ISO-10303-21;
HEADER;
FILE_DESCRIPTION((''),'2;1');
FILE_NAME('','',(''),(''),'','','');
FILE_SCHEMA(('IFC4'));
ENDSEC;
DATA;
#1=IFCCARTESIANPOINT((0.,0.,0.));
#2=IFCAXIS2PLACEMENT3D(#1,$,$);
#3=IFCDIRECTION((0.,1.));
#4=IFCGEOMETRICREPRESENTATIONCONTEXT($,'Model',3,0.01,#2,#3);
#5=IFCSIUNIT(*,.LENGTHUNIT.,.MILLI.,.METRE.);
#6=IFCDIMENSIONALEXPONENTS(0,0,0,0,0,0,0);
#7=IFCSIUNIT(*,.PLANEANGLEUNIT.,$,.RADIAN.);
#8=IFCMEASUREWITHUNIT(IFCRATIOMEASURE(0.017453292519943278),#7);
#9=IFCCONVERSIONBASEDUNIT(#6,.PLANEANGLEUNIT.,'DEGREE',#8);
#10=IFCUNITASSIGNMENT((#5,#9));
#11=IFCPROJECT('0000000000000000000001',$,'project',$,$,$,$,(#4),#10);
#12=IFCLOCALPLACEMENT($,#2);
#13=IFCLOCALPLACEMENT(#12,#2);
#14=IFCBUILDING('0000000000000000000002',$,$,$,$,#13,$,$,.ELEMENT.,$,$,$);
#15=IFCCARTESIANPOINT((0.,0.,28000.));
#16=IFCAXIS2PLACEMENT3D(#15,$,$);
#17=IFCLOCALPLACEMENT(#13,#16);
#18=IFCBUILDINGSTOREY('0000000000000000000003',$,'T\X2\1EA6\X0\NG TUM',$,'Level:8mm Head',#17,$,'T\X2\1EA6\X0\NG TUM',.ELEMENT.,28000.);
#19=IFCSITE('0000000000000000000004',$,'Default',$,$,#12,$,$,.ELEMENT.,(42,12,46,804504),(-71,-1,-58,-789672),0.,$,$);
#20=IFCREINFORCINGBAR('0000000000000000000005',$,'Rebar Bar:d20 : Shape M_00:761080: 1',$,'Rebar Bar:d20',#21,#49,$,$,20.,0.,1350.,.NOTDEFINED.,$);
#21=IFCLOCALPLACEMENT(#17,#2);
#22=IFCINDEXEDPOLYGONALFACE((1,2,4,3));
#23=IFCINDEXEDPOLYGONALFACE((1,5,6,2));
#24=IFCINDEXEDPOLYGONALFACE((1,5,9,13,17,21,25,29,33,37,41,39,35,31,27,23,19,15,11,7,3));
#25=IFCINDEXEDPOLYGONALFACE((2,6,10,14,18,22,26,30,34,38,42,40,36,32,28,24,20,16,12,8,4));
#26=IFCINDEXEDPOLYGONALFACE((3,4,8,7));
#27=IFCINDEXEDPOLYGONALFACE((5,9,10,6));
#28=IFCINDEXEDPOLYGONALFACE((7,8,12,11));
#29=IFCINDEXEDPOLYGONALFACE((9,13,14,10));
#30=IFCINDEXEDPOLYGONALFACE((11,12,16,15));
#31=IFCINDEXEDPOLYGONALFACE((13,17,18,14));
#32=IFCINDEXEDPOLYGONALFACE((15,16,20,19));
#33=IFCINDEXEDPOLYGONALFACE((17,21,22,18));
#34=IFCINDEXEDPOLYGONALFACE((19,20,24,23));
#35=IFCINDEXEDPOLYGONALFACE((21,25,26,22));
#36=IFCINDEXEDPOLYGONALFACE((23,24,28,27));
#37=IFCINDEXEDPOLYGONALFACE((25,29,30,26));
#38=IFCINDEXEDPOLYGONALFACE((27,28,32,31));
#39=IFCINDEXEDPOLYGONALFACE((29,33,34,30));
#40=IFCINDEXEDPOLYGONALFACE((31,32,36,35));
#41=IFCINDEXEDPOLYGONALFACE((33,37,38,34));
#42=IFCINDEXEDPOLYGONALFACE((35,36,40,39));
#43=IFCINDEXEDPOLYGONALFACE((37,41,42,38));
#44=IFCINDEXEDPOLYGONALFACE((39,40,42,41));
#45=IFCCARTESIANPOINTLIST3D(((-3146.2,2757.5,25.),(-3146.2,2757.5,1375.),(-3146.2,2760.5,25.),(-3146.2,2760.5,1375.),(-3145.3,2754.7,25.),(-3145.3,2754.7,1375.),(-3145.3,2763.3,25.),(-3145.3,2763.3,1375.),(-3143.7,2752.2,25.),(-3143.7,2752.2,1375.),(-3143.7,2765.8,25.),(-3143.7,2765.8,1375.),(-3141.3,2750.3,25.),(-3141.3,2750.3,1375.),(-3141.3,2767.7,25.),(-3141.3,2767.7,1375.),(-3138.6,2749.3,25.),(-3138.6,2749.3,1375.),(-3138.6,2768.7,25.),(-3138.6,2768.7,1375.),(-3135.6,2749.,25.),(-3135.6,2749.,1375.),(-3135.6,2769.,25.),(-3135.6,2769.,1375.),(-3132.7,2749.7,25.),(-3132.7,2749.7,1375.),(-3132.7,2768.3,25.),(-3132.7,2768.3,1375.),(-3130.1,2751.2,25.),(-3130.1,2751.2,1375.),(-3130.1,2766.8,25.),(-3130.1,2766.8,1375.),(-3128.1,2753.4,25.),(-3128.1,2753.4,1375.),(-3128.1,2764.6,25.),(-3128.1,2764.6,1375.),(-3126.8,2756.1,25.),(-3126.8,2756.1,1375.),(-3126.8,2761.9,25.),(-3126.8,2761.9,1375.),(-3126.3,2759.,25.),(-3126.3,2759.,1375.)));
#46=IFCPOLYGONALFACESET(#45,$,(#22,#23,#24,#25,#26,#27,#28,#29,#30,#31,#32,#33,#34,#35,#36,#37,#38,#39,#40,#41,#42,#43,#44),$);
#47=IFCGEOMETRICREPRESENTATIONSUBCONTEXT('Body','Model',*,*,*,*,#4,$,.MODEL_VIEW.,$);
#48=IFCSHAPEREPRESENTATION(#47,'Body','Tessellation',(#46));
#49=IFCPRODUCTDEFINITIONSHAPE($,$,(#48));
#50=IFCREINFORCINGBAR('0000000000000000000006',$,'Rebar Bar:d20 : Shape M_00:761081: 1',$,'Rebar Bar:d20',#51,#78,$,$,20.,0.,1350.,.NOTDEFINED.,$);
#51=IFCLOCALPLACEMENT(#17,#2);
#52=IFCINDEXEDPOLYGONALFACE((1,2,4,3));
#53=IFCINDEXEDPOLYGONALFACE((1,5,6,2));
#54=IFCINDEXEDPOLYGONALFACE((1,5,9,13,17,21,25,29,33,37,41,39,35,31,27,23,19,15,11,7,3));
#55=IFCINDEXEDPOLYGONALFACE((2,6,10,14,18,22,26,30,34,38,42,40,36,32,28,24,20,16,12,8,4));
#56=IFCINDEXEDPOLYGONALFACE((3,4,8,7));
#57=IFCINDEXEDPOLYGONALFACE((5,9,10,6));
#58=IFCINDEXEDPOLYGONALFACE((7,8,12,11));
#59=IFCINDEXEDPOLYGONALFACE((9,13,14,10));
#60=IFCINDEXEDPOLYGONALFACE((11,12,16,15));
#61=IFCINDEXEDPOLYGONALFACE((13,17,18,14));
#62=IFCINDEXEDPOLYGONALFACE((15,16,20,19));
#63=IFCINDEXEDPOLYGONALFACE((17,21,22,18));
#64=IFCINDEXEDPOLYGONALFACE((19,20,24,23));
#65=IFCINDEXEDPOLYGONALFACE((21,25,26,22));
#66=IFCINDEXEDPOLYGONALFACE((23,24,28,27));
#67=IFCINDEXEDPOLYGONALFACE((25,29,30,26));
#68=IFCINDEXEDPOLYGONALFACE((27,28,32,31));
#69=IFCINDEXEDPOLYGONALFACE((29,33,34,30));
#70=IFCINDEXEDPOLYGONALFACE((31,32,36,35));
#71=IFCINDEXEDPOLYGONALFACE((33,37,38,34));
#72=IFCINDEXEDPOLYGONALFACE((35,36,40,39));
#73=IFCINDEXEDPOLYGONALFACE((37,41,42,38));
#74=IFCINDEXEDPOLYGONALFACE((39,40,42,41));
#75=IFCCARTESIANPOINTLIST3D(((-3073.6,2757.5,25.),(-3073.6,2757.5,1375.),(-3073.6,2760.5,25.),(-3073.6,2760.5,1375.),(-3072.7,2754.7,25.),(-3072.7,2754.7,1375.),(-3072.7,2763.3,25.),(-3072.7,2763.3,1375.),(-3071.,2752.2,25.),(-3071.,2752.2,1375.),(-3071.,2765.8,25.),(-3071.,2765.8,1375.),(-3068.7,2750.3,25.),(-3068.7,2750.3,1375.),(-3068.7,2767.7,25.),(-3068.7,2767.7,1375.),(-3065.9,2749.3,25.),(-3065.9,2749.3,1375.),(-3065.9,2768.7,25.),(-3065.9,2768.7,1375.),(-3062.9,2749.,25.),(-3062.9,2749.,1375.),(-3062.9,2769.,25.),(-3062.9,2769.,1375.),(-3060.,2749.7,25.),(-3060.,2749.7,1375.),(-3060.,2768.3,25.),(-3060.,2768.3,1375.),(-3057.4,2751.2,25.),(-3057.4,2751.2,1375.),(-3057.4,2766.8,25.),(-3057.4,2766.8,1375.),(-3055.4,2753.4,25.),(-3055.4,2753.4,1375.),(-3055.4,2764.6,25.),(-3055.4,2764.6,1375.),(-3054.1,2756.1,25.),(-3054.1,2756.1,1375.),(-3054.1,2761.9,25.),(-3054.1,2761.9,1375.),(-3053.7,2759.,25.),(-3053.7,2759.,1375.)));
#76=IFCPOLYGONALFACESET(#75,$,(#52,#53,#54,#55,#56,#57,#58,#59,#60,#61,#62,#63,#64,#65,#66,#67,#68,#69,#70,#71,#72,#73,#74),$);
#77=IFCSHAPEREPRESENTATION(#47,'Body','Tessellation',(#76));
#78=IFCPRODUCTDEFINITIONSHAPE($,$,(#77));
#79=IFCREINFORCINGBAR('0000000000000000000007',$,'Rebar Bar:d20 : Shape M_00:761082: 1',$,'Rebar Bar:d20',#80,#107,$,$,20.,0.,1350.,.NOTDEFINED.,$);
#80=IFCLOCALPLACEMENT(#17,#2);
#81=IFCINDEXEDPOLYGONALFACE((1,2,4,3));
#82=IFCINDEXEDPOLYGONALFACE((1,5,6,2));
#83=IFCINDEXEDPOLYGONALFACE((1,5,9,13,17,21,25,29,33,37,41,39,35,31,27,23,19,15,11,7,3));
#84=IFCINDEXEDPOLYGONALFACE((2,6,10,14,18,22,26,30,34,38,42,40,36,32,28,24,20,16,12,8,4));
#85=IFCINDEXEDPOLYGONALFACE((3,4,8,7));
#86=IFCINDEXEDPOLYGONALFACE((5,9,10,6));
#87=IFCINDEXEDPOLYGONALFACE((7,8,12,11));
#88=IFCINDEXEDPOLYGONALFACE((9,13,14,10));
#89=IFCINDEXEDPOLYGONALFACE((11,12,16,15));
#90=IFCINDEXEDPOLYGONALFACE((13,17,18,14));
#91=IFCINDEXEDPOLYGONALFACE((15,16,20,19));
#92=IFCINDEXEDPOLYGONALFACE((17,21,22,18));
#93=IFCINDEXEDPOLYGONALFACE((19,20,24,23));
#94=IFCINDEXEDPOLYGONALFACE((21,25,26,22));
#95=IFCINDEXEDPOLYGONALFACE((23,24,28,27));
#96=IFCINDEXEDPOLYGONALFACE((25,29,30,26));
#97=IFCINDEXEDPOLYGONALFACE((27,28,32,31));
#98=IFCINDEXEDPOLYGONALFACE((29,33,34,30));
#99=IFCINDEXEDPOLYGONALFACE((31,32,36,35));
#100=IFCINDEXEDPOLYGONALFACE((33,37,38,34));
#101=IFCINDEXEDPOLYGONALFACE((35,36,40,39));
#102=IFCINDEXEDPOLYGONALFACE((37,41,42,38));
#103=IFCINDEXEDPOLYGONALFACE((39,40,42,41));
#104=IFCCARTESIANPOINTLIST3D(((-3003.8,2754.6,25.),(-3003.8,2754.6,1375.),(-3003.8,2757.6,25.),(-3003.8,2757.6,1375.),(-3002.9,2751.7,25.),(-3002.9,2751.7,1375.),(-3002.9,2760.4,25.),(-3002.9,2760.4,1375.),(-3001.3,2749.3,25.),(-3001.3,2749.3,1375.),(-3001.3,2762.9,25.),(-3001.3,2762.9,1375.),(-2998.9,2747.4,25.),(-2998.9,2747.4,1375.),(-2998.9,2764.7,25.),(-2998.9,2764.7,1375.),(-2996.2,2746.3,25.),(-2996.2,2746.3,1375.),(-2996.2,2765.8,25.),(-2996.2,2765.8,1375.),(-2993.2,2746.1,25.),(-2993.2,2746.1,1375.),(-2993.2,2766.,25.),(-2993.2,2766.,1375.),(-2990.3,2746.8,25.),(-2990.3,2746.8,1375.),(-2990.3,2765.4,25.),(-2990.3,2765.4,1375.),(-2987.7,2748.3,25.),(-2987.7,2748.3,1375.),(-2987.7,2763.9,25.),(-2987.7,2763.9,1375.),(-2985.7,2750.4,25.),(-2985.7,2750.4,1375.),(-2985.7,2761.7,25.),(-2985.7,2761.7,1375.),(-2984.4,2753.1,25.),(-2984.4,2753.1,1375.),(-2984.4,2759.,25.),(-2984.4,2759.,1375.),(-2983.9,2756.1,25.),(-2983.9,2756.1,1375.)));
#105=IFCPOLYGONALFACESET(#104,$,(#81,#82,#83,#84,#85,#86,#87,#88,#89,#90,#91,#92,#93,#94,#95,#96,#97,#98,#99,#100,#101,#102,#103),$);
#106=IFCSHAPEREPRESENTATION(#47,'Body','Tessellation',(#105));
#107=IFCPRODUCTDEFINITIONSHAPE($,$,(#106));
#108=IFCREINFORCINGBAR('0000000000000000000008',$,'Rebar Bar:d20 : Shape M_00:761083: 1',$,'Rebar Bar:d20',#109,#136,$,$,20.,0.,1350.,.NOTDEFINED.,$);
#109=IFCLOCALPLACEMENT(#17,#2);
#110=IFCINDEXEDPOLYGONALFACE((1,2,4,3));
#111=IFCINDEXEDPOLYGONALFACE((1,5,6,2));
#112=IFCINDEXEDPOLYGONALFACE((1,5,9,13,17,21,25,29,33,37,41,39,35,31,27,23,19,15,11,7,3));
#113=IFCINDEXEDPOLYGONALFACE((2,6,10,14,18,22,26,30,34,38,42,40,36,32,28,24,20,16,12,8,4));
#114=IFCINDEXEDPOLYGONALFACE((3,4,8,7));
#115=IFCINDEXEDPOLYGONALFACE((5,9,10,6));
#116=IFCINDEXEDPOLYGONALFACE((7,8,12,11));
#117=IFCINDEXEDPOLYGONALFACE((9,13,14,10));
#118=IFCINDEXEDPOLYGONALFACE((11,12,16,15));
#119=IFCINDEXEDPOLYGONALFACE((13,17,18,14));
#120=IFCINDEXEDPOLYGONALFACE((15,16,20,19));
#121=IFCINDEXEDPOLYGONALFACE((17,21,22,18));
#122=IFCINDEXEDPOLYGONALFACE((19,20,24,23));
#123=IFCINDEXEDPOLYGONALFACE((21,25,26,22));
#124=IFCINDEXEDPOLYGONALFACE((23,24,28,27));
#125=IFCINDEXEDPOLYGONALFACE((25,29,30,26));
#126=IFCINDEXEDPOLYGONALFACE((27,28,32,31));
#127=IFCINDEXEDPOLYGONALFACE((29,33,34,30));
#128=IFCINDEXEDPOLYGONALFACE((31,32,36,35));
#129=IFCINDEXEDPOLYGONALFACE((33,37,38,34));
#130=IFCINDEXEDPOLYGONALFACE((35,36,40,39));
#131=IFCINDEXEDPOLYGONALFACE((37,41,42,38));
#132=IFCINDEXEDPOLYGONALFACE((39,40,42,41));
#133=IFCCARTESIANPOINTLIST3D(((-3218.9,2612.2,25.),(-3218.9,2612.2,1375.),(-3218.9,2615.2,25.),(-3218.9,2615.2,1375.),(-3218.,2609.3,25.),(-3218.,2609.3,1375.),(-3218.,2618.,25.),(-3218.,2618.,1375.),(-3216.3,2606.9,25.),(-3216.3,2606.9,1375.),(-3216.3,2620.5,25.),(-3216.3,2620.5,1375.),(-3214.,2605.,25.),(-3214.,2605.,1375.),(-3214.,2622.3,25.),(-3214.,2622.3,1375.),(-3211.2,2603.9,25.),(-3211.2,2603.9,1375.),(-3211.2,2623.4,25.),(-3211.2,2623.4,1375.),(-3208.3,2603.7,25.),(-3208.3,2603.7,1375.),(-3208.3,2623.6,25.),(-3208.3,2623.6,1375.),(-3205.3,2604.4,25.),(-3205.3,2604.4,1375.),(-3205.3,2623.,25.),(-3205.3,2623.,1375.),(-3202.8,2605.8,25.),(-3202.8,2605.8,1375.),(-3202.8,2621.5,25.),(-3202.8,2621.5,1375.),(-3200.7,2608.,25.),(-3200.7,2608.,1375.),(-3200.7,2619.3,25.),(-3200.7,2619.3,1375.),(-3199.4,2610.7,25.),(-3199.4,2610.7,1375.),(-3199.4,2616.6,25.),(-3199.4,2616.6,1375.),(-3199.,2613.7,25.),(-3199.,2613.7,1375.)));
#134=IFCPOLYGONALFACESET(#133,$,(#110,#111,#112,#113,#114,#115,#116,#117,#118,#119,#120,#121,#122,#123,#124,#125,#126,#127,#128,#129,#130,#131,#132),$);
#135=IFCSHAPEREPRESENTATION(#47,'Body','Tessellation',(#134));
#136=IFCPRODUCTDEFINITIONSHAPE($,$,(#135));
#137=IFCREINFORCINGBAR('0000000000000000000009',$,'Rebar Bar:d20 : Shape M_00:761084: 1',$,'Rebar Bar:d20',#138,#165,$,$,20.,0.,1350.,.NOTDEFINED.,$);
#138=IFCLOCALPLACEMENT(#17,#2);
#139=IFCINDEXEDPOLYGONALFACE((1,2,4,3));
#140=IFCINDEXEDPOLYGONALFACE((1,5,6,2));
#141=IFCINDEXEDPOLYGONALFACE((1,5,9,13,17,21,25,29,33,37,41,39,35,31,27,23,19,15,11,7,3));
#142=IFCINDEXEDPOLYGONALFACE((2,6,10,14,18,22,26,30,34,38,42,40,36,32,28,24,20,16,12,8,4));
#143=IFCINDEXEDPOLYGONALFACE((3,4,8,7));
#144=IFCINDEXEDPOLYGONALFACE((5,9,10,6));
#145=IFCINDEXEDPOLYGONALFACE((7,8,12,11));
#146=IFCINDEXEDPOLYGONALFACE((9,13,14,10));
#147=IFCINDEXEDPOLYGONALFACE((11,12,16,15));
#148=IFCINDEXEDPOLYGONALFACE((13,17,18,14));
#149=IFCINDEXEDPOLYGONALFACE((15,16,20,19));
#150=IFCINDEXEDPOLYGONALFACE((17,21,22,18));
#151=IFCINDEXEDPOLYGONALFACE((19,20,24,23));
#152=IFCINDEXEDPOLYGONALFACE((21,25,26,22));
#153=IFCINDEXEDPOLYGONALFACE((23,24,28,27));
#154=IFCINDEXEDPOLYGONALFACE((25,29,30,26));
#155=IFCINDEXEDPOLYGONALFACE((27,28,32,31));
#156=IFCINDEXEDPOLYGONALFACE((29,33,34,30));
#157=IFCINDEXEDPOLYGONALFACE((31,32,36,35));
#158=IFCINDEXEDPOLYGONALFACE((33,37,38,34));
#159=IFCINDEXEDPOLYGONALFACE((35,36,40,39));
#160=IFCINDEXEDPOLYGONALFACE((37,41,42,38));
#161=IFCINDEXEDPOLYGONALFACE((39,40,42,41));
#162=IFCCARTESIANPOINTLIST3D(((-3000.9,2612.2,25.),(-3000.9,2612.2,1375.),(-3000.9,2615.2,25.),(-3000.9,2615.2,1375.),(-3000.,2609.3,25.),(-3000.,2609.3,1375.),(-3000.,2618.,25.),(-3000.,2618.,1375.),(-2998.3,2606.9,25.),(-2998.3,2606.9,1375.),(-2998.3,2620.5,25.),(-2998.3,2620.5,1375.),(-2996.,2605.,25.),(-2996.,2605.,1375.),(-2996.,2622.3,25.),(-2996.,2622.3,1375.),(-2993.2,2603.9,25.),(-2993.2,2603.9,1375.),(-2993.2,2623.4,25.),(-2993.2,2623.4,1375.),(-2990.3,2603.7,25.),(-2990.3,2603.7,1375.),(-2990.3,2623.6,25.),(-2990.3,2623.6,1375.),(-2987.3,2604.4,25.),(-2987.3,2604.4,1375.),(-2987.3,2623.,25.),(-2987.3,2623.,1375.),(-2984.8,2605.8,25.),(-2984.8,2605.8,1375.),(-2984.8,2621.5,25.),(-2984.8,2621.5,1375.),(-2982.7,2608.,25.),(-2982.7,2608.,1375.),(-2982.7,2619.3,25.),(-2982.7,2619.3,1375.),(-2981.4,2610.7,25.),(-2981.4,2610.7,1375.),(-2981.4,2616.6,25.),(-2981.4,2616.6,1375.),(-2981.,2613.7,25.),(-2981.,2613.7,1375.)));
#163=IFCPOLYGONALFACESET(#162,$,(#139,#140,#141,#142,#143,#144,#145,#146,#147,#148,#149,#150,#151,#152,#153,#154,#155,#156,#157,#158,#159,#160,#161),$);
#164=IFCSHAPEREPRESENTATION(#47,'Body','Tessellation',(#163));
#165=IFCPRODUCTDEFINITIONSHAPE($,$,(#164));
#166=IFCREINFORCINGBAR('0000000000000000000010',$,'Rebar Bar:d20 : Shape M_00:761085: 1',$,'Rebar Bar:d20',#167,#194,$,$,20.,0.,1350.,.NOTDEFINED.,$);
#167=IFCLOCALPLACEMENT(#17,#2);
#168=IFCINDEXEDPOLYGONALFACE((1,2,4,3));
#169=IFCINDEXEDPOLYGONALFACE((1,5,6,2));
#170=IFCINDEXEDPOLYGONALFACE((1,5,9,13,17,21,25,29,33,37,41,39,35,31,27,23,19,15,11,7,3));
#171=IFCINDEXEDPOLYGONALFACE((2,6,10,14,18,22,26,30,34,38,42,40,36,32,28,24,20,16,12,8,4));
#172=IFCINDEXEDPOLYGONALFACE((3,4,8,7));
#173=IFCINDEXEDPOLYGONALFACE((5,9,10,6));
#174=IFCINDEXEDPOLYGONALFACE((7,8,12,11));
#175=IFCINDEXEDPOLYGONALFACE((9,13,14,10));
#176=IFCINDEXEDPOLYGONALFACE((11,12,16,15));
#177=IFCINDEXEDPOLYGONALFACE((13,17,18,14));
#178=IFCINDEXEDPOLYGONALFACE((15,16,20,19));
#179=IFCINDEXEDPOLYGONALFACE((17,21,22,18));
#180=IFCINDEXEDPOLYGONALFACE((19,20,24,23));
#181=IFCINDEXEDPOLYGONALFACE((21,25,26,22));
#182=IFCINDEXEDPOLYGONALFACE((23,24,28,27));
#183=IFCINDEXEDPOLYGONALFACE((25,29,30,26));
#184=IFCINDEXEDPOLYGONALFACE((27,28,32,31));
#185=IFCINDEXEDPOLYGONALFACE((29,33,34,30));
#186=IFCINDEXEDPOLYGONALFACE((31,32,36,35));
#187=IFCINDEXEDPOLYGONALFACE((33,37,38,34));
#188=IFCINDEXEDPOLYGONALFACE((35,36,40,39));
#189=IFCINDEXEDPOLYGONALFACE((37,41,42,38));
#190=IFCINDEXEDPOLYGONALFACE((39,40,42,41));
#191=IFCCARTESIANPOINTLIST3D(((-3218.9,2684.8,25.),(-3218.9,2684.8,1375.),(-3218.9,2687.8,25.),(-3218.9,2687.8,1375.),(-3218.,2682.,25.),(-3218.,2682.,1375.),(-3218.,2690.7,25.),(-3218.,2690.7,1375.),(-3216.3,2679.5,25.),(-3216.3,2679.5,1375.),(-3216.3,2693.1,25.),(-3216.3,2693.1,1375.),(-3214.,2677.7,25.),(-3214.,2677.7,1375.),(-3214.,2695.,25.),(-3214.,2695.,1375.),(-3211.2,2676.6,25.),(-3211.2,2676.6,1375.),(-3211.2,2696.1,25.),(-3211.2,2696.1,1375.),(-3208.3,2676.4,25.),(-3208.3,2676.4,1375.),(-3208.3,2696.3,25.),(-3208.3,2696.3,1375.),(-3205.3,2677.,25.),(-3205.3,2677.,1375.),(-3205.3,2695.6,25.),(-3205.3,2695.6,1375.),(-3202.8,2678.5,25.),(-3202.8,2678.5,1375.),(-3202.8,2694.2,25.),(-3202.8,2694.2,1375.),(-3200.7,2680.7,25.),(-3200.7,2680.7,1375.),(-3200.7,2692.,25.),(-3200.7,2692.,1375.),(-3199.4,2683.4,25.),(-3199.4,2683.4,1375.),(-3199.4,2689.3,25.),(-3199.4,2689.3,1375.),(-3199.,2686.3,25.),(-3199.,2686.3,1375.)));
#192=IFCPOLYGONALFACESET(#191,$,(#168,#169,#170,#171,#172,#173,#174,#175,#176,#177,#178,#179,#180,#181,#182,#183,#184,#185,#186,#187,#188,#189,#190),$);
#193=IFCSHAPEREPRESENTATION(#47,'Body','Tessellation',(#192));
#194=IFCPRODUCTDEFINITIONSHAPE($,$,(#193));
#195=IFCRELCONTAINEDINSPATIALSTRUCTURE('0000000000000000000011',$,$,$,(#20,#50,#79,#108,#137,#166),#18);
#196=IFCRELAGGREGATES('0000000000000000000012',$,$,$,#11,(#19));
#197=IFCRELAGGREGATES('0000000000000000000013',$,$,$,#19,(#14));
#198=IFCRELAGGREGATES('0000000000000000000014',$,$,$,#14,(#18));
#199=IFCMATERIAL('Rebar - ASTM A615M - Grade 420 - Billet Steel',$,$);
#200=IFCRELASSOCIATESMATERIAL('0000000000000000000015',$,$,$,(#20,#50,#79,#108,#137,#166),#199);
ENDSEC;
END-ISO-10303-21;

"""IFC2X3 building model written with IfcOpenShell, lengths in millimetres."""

from ifc_helpers import new_model, entity, si_unit, converted_unit, direction, frame, origin, place, context, subcontext, project, spatial, material, element, save


model = new_model("IFC2X3")

# Units and contexts
model_context = context("Model", 3, precision=0.01, world=origin(), true_north=direction((0.0, 1.0)))
body_context = subcontext(model_context, "Body", "Model", "MODEL_VIEW")
ifc_project = project(units=[si_unit("LENGTHUNIT", "METRE", prefix="MILLI"), converted_unit("PLANEANGLEUNIT", "DEGREE", entity("IfcRatioMeasure", 0.017453292519943278), si_unit("PLANEANGLEUNIT", "RADIAN"), dimensions=[0, 0, 0, 0, 0, 0, 0])], contexts=[model_context])

# Site, building, storey
site_placement = place(None, origin())
site = spatial("IfcSite", under=ifc_project, at=site_placement, Name="Default", CompositionType="ELEMENT", RefLatitude=(42, 12, 46, 804504), RefLongitude=(-71, -1, -58, -789672), RefElevation=0.0)
building_placement = place(site_placement, origin())
building = spatial("IfcBuilding", under=site, at=building_placement, CompositionType="ELEMENT")
storey_placement = place(building_placement, frame((0.0, 0.0, 28000.0)))
storey = spatial("IfcBuildingStorey", under=building, at=storey_placement, Name="TẦNG TUM", ObjectType="Level:8mm Head", LongName="TẦNG TUM", CompositionType="ELEMENT", Elevation=28000.0)

# Reinforcing bars
ifc_material = material(Name="Rebar - ASTM A615M - Grade 420 - Billet Steel")
reinforcing_bar_1_placement = place(storey_placement, origin())
element("IfcReinforcingBar", 1, at=reinforcing_bar_1_placement, inside=storey, material=ifc_material, Name="Rebar Bar:d20 : Shape M_00:761080: 1", ObjectType="Rebar Bar:d20", BarLength=1350.0, BarRole="NOTDEFINED", CrossSectionArea=0.0, NominalDiameter=20.0, context=body_context, shape_type="AdvancedSweptSolid", body=[
    entity("IfcSweptDiskSolid", entity("IfcCompositeCurve", [entity("IfcCompositeCurveSegment", "CONTINUOUS", True, entity("IfcPolyline", [entity("IfcCartesianPoint", [-3136.3, 2759.0, 25.0]), entity("IfcCartesianPoint", [-3136.3, 2759.0, 1375.0])]))], False), 10.0, None, 0.0, 1.0),
])
reinforcing_bar_2_placement = place(storey_placement, origin())
element("IfcReinforcingBar", 2, at=reinforcing_bar_2_placement, inside=storey, material=ifc_material, Name="Rebar Bar:d20 : Shape M_00:761081: 1", ObjectType="Rebar Bar:d20", BarLength=1350.0, BarRole="NOTDEFINED", CrossSectionArea=0.0, NominalDiameter=20.0, context=body_context, shape_type="AdvancedSweptSolid", body=[
    entity("IfcSweptDiskSolid", entity("IfcCompositeCurve", [entity("IfcCompositeCurveSegment", "CONTINUOUS", True, entity("IfcPolyline", [entity("IfcCartesianPoint", [-3063.7, 2759.0, 25.0]), entity("IfcCartesianPoint", [-3063.7, 2759.0, 1375.0])]))], False), 10.0, None, 0.0, 1.0),
])
reinforcing_bar_3_placement = place(storey_placement, origin())
element("IfcReinforcingBar", 3, at=reinforcing_bar_3_placement, inside=storey, material=ifc_material, Name="Rebar Bar:d20 : Shape M_00:761082: 1", ObjectType="Rebar Bar:d20", BarLength=1350.0, BarRole="NOTDEFINED", CrossSectionArea=0.0, NominalDiameter=20.0, context=body_context, shape_type="AdvancedSweptSolid", body=[
    entity("IfcSweptDiskSolid", entity("IfcCompositeCurve", [entity("IfcCompositeCurveSegment", "CONTINUOUS", True, entity("IfcPolyline", [entity("IfcCartesianPoint", [-2993.9, 2756.1, 25.0]), entity("IfcCartesianPoint", [-2993.9, 2756.1, 1375.0])]))], False), 10.0, None, 0.0, 1.0),
])
reinforcing_bar_4_placement = place(storey_placement, origin())
element("IfcReinforcingBar", 4, at=reinforcing_bar_4_placement, inside=storey, material=ifc_material, Name="Rebar Bar:d20 : Shape M_00:761083: 1", ObjectType="Rebar Bar:d20", BarLength=1350.0, BarRole="NOTDEFINED", CrossSectionArea=0.0, NominalDiameter=20.0, context=body_context, shape_type="AdvancedSweptSolid", body=[
    entity("IfcSweptDiskSolid", entity("IfcCompositeCurve", [entity("IfcCompositeCurveSegment", "CONTINUOUS", True, entity("IfcPolyline", [entity("IfcCartesianPoint", [-3209.0, 2613.7, 25.0]), entity("IfcCartesianPoint", [-3209.0, 2613.7, 1375.0])]))], False), 10.0, None, 0.0, 1.0),
])
reinforcing_bar_5_placement = place(storey_placement, origin())
element("IfcReinforcingBar", 5, at=reinforcing_bar_5_placement, inside=storey, material=ifc_material, Name="Rebar Bar:d20 : Shape M_00:761084: 1", ObjectType="Rebar Bar:d20", BarLength=1350.0, BarRole="NOTDEFINED", CrossSectionArea=0.0, NominalDiameter=20.0, context=body_context, shape_type="AdvancedSweptSolid", body=[
    entity("IfcSweptDiskSolid", entity("IfcCompositeCurve", [entity("IfcCompositeCurveSegment", "CONTINUOUS", True, entity("IfcPolyline", [entity("IfcCartesianPoint", [-2991.0, 2613.7, 25.0]), entity("IfcCartesianPoint", [-2991.0, 2613.7, 1375.0])]))], False), 10.0, None, 0.0, 1.0),
])
reinforcing_bar_6_placement = place(storey_placement, origin())
element("IfcReinforcingBar", 6, at=reinforcing_bar_6_placement, inside=storey, material=ifc_material, Name="Rebar Bar:d20 : Shape M_00:761085: 1", ObjectType="Rebar Bar:d20", BarLength=1350.0, BarRole="NOTDEFINED", CrossSectionArea=0.0, NominalDiameter=20.0, context=body_context, shape_type="AdvancedSweptSolid", body=[
    entity("IfcSweptDiskSolid", entity("IfcCompositeCurve", [entity("IfcCompositeCurveSegment", "CONTINUOUS", True, entity("IfcPolyline", [entity("IfcCartesianPoint", [-3209.0, 2686.3, 25.0]), entity("IfcCartesianPoint", [-3209.0, 2686.3, 1375.0])]))], False), 10.0, None, 0.0, 1.0),
])

save(model, "model.ifc")
